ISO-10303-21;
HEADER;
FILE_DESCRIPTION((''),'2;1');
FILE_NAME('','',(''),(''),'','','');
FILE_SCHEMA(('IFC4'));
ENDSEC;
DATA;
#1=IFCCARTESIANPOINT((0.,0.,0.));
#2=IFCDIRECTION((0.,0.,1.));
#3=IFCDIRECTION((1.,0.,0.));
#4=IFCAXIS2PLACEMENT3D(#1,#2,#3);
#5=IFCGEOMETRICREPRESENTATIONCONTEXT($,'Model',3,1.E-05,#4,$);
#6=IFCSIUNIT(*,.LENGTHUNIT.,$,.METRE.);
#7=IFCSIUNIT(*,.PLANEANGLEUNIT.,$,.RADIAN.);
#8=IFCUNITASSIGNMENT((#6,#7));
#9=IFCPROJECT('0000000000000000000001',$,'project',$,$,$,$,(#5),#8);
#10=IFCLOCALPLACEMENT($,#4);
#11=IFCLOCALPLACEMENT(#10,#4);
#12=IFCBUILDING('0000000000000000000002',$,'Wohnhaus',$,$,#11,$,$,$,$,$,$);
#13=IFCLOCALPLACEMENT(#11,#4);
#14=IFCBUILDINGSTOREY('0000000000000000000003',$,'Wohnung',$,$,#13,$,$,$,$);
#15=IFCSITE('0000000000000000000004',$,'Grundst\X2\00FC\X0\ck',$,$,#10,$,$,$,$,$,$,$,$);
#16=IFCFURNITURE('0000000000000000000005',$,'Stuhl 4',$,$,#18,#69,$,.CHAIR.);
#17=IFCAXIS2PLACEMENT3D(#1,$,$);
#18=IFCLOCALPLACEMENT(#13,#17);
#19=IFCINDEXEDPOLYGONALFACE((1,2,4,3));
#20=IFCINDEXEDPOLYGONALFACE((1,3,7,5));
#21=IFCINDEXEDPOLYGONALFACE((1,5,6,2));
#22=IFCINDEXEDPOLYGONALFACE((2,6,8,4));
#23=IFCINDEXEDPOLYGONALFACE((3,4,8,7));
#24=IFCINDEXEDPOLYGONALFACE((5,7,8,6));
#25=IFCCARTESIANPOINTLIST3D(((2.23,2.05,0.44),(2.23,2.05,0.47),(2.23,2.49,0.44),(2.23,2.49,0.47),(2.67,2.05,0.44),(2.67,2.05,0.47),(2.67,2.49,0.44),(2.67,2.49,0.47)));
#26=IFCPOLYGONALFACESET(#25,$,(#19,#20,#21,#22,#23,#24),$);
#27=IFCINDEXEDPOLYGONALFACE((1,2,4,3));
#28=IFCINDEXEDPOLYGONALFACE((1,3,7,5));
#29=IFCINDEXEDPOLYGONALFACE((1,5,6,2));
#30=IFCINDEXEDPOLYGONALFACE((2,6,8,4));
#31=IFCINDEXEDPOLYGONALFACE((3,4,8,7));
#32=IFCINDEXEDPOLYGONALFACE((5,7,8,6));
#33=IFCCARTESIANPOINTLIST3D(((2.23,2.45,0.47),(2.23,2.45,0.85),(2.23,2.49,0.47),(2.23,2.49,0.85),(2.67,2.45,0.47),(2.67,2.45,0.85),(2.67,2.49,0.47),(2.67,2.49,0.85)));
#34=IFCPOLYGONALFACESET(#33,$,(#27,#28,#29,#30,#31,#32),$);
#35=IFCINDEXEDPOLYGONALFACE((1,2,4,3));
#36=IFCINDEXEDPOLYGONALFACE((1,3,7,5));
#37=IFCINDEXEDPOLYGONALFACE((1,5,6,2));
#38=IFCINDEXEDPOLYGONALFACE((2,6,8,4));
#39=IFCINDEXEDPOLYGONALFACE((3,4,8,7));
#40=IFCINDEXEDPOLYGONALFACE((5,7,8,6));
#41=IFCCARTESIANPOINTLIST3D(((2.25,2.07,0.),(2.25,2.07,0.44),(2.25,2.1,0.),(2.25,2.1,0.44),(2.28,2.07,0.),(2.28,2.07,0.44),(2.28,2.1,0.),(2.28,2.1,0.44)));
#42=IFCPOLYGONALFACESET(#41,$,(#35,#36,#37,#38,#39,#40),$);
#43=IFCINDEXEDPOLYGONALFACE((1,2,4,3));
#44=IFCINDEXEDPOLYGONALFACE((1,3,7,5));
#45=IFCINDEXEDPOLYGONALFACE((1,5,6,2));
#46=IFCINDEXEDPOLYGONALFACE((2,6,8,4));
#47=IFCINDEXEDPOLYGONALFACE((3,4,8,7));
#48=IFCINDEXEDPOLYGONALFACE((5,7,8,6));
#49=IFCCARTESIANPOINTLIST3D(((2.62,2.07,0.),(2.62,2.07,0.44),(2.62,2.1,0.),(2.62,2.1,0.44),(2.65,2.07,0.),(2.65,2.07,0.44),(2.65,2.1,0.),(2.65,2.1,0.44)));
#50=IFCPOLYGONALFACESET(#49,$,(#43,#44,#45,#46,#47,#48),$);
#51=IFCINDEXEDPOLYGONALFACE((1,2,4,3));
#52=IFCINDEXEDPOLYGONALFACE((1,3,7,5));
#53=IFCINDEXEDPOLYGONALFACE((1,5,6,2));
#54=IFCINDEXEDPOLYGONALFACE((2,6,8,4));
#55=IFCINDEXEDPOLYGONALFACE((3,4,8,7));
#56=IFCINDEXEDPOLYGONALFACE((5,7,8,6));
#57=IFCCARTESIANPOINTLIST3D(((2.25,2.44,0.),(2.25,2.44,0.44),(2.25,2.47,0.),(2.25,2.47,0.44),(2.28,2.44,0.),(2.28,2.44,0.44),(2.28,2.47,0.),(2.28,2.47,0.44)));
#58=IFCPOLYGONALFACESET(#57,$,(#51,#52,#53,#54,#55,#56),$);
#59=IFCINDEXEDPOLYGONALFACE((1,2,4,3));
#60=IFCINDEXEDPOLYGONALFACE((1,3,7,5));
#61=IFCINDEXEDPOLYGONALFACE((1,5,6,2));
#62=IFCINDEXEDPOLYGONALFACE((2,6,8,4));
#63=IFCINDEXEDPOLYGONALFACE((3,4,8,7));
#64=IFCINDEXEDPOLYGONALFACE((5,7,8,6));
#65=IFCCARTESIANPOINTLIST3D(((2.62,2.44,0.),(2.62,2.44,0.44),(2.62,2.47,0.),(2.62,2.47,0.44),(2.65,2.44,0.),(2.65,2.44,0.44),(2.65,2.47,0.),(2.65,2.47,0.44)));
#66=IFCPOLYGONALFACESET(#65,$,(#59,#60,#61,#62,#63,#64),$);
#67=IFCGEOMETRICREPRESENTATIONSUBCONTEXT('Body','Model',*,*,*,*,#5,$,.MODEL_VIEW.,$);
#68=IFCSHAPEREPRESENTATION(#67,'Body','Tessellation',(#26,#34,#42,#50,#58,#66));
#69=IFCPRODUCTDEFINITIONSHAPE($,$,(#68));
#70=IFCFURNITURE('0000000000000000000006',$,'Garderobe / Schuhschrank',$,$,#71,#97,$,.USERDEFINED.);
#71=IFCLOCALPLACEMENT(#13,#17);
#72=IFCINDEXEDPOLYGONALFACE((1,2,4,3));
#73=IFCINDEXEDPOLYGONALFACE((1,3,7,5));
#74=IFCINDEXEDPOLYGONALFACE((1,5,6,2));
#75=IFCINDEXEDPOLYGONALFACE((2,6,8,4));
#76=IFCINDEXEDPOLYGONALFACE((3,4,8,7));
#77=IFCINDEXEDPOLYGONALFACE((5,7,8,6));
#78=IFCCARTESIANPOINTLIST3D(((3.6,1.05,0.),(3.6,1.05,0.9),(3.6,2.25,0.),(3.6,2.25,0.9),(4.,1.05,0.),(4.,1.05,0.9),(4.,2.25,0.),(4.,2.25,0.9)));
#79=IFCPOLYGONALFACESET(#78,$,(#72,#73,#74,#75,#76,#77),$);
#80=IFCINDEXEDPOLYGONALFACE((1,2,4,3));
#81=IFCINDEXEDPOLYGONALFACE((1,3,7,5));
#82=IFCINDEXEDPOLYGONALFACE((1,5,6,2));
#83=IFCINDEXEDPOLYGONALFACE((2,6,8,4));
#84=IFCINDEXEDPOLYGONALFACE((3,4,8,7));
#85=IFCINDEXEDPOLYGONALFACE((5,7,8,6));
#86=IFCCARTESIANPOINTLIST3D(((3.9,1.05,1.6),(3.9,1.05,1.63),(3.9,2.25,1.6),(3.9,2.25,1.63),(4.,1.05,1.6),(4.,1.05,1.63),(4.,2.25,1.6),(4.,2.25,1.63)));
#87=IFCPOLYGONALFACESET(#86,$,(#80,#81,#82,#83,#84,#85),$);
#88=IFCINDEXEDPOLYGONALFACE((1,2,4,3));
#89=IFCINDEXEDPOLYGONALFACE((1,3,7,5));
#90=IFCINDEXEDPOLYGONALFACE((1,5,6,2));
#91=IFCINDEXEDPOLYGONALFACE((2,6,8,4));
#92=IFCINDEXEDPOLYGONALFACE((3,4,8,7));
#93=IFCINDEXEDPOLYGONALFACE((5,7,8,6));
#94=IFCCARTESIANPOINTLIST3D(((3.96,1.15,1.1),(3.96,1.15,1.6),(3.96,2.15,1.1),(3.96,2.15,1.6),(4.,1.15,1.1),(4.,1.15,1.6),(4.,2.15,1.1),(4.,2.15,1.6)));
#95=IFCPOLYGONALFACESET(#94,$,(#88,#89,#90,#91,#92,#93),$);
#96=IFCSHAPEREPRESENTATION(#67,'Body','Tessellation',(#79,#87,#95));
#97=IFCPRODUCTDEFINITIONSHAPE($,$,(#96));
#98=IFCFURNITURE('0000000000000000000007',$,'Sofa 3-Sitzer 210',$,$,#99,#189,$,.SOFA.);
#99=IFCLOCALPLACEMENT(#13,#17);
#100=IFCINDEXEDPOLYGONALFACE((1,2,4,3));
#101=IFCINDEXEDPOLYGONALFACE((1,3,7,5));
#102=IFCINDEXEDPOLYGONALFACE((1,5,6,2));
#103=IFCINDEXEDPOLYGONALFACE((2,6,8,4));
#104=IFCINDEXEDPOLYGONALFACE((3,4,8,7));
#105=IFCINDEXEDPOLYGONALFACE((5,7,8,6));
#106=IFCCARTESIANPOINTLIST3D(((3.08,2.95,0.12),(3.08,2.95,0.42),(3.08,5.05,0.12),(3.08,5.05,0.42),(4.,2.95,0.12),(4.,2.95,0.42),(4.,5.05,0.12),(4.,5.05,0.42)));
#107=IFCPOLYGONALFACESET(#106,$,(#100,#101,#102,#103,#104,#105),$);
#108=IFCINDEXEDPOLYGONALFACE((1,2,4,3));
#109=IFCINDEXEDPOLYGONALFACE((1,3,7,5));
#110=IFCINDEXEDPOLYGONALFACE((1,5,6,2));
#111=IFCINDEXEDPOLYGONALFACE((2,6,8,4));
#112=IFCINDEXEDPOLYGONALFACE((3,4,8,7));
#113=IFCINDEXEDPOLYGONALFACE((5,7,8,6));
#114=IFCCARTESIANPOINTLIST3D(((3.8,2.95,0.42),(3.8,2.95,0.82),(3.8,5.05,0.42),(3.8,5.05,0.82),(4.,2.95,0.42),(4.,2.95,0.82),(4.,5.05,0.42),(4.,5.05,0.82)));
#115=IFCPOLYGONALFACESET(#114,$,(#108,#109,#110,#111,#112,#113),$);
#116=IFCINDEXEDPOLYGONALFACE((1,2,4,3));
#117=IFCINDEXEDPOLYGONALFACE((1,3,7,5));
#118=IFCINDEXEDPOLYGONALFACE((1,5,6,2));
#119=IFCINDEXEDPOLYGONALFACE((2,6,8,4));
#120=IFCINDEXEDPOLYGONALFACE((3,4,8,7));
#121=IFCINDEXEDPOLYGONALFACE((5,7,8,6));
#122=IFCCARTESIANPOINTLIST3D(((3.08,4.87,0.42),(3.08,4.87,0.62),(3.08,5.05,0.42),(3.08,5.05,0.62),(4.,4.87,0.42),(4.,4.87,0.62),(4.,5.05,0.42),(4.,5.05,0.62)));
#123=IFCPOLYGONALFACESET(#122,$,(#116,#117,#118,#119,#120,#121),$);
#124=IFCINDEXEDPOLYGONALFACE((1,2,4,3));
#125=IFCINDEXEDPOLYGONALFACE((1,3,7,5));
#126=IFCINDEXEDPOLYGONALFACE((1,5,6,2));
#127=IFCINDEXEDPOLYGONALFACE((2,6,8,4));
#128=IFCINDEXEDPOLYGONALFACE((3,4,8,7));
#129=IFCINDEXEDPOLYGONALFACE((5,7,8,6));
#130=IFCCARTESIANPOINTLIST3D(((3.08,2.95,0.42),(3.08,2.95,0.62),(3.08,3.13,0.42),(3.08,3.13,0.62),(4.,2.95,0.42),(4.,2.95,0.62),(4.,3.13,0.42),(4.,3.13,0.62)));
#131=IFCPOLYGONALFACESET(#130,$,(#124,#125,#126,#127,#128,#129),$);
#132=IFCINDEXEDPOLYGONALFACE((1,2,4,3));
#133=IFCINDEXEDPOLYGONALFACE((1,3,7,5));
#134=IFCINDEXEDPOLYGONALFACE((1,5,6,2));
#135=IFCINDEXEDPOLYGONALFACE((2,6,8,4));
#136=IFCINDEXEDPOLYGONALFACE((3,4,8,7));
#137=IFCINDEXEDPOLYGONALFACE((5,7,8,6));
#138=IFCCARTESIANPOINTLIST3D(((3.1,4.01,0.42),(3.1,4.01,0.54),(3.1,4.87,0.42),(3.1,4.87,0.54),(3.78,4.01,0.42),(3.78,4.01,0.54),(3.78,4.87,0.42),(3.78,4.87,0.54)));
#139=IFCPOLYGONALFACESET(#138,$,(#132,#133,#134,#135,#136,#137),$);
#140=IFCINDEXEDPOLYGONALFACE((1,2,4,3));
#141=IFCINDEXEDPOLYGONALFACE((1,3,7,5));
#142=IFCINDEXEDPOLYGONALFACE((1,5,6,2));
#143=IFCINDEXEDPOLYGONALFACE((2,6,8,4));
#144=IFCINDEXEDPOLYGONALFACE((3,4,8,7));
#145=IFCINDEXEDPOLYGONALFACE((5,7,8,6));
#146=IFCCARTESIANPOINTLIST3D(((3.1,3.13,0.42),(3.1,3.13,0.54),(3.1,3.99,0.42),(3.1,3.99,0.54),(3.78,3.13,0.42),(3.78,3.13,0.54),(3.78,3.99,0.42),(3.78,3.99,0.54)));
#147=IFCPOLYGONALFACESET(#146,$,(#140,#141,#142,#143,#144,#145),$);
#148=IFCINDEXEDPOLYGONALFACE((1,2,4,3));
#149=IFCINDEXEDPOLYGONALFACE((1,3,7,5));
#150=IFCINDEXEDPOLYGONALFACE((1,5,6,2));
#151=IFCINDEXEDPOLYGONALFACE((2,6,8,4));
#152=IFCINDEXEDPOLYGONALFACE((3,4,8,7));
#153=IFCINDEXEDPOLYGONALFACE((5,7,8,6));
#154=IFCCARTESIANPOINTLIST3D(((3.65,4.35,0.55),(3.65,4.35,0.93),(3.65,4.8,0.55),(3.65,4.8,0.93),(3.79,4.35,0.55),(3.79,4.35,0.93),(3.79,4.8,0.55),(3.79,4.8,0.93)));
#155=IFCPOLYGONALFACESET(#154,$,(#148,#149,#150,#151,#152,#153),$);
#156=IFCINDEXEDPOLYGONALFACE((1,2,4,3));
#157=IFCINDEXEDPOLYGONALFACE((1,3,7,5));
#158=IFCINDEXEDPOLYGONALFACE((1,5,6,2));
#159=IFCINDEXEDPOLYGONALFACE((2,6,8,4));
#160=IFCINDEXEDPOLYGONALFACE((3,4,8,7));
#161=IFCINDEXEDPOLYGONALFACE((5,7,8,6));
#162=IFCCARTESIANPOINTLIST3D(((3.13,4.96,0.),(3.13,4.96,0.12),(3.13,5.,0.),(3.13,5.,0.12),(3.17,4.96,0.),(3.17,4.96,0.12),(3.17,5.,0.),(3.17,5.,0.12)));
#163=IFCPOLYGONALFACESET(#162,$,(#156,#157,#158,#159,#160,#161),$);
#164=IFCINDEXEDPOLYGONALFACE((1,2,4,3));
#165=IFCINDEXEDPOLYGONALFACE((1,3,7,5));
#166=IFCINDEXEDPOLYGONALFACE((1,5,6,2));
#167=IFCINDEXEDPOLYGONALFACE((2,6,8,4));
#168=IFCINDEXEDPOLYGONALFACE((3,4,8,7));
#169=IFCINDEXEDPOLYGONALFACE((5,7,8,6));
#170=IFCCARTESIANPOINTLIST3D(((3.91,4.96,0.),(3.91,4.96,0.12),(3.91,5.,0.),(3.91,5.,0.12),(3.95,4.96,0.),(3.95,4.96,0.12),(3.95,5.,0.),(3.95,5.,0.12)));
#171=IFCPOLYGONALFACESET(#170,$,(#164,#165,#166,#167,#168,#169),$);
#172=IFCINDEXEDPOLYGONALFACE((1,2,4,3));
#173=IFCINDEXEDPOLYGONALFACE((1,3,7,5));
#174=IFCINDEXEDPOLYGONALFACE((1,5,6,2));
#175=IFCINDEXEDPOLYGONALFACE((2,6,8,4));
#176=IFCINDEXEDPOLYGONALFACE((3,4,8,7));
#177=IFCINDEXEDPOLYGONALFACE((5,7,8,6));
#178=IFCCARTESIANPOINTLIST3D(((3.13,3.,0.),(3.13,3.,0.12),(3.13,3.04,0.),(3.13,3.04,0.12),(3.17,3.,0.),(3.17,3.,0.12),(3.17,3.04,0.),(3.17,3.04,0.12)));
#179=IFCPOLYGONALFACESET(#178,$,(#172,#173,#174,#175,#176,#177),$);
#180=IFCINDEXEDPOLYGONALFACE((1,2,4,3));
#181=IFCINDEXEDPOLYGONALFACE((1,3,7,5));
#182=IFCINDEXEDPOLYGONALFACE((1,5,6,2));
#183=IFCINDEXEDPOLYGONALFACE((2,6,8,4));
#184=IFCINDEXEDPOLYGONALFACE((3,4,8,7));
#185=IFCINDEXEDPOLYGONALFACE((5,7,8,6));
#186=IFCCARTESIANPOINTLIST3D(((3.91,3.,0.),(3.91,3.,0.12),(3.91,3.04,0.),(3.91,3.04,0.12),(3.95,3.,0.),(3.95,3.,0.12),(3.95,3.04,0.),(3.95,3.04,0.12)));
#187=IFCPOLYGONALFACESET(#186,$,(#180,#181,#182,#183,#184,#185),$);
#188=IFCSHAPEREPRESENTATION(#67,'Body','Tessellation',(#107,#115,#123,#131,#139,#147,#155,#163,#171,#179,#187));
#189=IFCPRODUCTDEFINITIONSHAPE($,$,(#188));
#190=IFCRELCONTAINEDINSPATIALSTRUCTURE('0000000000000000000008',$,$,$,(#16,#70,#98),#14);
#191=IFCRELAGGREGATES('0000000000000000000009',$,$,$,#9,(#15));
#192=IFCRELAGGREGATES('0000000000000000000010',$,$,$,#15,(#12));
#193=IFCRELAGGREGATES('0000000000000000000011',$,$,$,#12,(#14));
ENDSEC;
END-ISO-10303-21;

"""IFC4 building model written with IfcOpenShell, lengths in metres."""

from ifc_helpers import new_model, si_unit, frame, frame_2d, origin, origin_with_axes, place, context, subcontext, project, spatial, rectangle, extrude, element, save


model = new_model("IFC4")

# Units and contexts
model_context = context("Model", 3, precision=1e-05, world=origin_with_axes())
body_context = subcontext(model_context, "Body", "Model", "MODEL_VIEW")
ifc_project = project(units=[si_unit("LENGTHUNIT", "METRE"), si_unit("PLANEANGLEUNIT", "RADIAN")], contexts=[model_context])

# Site, building, storey
site_placement = place(None, origin_with_axes())
site = spatial("IfcSite", under=ifc_project, at=site_placement, Name="Grundstück")
building_placement = place(site_placement, origin_with_axes())
building = spatial("IfcBuilding", under=site, at=building_placement, Name="Wohnhaus")
storey_placement = place(building_placement, origin_with_axes())
storey = spatial("IfcBuildingStorey", under=building, at=storey_placement, Name="Wohnung")

# Furniture
for number, where, z_axis, x_axis, name in (
    (1, (2.23, 2.05, 0.0), (0.0, 0.0, 1.0), (1.0, 0.0, 0.0), "Stuhl 4"),
):
    element("IfcFurniture", number, at=place(storey_placement, frame(where, z_axis=z_axis, x_axis=x_axis)), inside=storey, Name=name, PredefinedType="CHAIR", context=body_context, shape_type="SweptSolid", body=[
        extrude(rectangle(XDim=0.44, YDim=0.44, at=frame_2d((0.22, 0.22))), frame((0.0, 0.0, 0.44)), (0.0, 0.0, 1.0), 0.03),
        extrude(rectangle(XDim=0.44, YDim=0.04, at=frame_2d((0.22, 0.42))), frame((0.0, 0.0, 0.47)), (0.0, 0.0, 1.0), 0.38),
        extrude(rectangle(XDim=0.03, YDim=0.03, at=frame_2d((0.035, 0.035))), origin(), (0.0, 0.0, 1.0), 0.44),
        extrude(rectangle(XDim=0.03, YDim=0.03, at=frame_2d((0.405, 0.035))), origin(), (0.0, 0.0, 1.0), 0.44),
        extrude(rectangle(XDim=0.03, YDim=0.03, at=frame_2d((0.035, 0.405))), origin(), (0.0, 0.0, 1.0), 0.44),
        extrude(rectangle(XDim=0.03, YDim=0.03, at=frame_2d((0.405, 0.405))), origin(), (0.0, 0.0, 1.0), 0.44),
    ])
furniture_1_placement = place(storey_placement, frame((3.6, 2.25, 0.0), z_axis=(0.0, 0.0, 1.0), x_axis=(0.0, -1.0, 0.0)))
element("IfcFurniture", 2, at=furniture_1_placement, inside=storey, Name="Garderobe / Schuhschrank", PredefinedType="USERDEFINED", context=body_context, shape_type="SweptSolid", body=[
    extrude(rectangle(XDim=1.2, YDim=0.4, at=frame_2d((0.6, 0.2))), origin(), (0.0, 0.0, 1.0), 0.9),
    extrude(rectangle(XDim=1.2, YDim=0.1, at=frame_2d((0.6, 0.35))), frame((0.0, 0.0, 1.6)), (0.0, 0.0, 1.0), 0.03),
    extrude(rectangle(XDim=1.0, YDim=0.04, at=frame_2d((0.6, 0.38))), frame((0.0, 0.0, 1.1)), (0.0, 0.0, 1.0), 0.5),
])
furniture_2_placement = place(storey_placement, frame((3.08, 5.05, 0.0), z_axis=(0.0, 0.0, 1.0), x_axis=(0.0, -1.0, 0.0)))
element("IfcFurniture", 3, at=furniture_2_placement, inside=storey, Name="Sofa 3-Sitzer 210", PredefinedType="SOFA", context=body_context, shape_type="SweptSolid", body=[
    extrude(rectangle(XDim=2.1, YDim=0.92, at=frame_2d((1.05, 0.46))), frame((0.0, 0.0, 0.12)), (0.0, 0.0, 1.0), 0.3),
    extrude(rectangle(XDim=2.1, YDim=0.2, at=frame_2d((1.05, 0.82))), frame((0.0, 0.0, 0.42)), (0.0, 0.0, 1.0), 0.4),
    extrude(rectangle(XDim=0.18, YDim=0.92, at=frame_2d((0.09, 0.46))), frame((0.0, 0.0, 0.42)), (0.0, 0.0, 1.0), 0.2),
    extrude(rectangle(XDim=0.18, YDim=0.92, at=frame_2d((2.01, 0.46))), frame((0.0, 0.0, 0.42)), (0.0, 0.0, 1.0), 0.2),
    extrude(rectangle(XDim=0.86, YDim=0.68, at=frame_2d((0.61, 0.36))), frame((0.0, 0.0, 0.42)), (0.0, 0.0, 1.0), 0.12),
    extrude(rectangle(XDim=0.86, YDim=0.68, at=frame_2d((1.49, 0.36))), frame((0.0, 0.0, 0.42)), (0.0, 0.0, 1.0), 0.12),
    extrude(rectangle(XDim=0.45, YDim=0.14, at=frame_2d((0.475, 0.64))), frame((0.0, 0.0, 0.55)), (0.0, 0.0, 1.0), 0.38),
    extrude(rectangle(XDim=0.04, YDim=0.04, at=frame_2d((0.07, 0.07))), origin(), (0.0, 0.0, 1.0), 0.12),
    extrude(rectangle(XDim=0.04, YDim=0.04, at=frame_2d((0.07, 0.85))), origin(), (0.0, 0.0, 1.0), 0.12),
    extrude(rectangle(XDim=0.04, YDim=0.04, at=frame_2d((2.03, 0.07))), origin(), (0.0, 0.0, 1.0), 0.12),
    extrude(rectangle(XDim=0.04, YDim=0.04, at=frame_2d((2.03, 0.85))), origin(), (0.0, 0.0, 1.0), 0.12),
])

save(model, "model.ifc")
